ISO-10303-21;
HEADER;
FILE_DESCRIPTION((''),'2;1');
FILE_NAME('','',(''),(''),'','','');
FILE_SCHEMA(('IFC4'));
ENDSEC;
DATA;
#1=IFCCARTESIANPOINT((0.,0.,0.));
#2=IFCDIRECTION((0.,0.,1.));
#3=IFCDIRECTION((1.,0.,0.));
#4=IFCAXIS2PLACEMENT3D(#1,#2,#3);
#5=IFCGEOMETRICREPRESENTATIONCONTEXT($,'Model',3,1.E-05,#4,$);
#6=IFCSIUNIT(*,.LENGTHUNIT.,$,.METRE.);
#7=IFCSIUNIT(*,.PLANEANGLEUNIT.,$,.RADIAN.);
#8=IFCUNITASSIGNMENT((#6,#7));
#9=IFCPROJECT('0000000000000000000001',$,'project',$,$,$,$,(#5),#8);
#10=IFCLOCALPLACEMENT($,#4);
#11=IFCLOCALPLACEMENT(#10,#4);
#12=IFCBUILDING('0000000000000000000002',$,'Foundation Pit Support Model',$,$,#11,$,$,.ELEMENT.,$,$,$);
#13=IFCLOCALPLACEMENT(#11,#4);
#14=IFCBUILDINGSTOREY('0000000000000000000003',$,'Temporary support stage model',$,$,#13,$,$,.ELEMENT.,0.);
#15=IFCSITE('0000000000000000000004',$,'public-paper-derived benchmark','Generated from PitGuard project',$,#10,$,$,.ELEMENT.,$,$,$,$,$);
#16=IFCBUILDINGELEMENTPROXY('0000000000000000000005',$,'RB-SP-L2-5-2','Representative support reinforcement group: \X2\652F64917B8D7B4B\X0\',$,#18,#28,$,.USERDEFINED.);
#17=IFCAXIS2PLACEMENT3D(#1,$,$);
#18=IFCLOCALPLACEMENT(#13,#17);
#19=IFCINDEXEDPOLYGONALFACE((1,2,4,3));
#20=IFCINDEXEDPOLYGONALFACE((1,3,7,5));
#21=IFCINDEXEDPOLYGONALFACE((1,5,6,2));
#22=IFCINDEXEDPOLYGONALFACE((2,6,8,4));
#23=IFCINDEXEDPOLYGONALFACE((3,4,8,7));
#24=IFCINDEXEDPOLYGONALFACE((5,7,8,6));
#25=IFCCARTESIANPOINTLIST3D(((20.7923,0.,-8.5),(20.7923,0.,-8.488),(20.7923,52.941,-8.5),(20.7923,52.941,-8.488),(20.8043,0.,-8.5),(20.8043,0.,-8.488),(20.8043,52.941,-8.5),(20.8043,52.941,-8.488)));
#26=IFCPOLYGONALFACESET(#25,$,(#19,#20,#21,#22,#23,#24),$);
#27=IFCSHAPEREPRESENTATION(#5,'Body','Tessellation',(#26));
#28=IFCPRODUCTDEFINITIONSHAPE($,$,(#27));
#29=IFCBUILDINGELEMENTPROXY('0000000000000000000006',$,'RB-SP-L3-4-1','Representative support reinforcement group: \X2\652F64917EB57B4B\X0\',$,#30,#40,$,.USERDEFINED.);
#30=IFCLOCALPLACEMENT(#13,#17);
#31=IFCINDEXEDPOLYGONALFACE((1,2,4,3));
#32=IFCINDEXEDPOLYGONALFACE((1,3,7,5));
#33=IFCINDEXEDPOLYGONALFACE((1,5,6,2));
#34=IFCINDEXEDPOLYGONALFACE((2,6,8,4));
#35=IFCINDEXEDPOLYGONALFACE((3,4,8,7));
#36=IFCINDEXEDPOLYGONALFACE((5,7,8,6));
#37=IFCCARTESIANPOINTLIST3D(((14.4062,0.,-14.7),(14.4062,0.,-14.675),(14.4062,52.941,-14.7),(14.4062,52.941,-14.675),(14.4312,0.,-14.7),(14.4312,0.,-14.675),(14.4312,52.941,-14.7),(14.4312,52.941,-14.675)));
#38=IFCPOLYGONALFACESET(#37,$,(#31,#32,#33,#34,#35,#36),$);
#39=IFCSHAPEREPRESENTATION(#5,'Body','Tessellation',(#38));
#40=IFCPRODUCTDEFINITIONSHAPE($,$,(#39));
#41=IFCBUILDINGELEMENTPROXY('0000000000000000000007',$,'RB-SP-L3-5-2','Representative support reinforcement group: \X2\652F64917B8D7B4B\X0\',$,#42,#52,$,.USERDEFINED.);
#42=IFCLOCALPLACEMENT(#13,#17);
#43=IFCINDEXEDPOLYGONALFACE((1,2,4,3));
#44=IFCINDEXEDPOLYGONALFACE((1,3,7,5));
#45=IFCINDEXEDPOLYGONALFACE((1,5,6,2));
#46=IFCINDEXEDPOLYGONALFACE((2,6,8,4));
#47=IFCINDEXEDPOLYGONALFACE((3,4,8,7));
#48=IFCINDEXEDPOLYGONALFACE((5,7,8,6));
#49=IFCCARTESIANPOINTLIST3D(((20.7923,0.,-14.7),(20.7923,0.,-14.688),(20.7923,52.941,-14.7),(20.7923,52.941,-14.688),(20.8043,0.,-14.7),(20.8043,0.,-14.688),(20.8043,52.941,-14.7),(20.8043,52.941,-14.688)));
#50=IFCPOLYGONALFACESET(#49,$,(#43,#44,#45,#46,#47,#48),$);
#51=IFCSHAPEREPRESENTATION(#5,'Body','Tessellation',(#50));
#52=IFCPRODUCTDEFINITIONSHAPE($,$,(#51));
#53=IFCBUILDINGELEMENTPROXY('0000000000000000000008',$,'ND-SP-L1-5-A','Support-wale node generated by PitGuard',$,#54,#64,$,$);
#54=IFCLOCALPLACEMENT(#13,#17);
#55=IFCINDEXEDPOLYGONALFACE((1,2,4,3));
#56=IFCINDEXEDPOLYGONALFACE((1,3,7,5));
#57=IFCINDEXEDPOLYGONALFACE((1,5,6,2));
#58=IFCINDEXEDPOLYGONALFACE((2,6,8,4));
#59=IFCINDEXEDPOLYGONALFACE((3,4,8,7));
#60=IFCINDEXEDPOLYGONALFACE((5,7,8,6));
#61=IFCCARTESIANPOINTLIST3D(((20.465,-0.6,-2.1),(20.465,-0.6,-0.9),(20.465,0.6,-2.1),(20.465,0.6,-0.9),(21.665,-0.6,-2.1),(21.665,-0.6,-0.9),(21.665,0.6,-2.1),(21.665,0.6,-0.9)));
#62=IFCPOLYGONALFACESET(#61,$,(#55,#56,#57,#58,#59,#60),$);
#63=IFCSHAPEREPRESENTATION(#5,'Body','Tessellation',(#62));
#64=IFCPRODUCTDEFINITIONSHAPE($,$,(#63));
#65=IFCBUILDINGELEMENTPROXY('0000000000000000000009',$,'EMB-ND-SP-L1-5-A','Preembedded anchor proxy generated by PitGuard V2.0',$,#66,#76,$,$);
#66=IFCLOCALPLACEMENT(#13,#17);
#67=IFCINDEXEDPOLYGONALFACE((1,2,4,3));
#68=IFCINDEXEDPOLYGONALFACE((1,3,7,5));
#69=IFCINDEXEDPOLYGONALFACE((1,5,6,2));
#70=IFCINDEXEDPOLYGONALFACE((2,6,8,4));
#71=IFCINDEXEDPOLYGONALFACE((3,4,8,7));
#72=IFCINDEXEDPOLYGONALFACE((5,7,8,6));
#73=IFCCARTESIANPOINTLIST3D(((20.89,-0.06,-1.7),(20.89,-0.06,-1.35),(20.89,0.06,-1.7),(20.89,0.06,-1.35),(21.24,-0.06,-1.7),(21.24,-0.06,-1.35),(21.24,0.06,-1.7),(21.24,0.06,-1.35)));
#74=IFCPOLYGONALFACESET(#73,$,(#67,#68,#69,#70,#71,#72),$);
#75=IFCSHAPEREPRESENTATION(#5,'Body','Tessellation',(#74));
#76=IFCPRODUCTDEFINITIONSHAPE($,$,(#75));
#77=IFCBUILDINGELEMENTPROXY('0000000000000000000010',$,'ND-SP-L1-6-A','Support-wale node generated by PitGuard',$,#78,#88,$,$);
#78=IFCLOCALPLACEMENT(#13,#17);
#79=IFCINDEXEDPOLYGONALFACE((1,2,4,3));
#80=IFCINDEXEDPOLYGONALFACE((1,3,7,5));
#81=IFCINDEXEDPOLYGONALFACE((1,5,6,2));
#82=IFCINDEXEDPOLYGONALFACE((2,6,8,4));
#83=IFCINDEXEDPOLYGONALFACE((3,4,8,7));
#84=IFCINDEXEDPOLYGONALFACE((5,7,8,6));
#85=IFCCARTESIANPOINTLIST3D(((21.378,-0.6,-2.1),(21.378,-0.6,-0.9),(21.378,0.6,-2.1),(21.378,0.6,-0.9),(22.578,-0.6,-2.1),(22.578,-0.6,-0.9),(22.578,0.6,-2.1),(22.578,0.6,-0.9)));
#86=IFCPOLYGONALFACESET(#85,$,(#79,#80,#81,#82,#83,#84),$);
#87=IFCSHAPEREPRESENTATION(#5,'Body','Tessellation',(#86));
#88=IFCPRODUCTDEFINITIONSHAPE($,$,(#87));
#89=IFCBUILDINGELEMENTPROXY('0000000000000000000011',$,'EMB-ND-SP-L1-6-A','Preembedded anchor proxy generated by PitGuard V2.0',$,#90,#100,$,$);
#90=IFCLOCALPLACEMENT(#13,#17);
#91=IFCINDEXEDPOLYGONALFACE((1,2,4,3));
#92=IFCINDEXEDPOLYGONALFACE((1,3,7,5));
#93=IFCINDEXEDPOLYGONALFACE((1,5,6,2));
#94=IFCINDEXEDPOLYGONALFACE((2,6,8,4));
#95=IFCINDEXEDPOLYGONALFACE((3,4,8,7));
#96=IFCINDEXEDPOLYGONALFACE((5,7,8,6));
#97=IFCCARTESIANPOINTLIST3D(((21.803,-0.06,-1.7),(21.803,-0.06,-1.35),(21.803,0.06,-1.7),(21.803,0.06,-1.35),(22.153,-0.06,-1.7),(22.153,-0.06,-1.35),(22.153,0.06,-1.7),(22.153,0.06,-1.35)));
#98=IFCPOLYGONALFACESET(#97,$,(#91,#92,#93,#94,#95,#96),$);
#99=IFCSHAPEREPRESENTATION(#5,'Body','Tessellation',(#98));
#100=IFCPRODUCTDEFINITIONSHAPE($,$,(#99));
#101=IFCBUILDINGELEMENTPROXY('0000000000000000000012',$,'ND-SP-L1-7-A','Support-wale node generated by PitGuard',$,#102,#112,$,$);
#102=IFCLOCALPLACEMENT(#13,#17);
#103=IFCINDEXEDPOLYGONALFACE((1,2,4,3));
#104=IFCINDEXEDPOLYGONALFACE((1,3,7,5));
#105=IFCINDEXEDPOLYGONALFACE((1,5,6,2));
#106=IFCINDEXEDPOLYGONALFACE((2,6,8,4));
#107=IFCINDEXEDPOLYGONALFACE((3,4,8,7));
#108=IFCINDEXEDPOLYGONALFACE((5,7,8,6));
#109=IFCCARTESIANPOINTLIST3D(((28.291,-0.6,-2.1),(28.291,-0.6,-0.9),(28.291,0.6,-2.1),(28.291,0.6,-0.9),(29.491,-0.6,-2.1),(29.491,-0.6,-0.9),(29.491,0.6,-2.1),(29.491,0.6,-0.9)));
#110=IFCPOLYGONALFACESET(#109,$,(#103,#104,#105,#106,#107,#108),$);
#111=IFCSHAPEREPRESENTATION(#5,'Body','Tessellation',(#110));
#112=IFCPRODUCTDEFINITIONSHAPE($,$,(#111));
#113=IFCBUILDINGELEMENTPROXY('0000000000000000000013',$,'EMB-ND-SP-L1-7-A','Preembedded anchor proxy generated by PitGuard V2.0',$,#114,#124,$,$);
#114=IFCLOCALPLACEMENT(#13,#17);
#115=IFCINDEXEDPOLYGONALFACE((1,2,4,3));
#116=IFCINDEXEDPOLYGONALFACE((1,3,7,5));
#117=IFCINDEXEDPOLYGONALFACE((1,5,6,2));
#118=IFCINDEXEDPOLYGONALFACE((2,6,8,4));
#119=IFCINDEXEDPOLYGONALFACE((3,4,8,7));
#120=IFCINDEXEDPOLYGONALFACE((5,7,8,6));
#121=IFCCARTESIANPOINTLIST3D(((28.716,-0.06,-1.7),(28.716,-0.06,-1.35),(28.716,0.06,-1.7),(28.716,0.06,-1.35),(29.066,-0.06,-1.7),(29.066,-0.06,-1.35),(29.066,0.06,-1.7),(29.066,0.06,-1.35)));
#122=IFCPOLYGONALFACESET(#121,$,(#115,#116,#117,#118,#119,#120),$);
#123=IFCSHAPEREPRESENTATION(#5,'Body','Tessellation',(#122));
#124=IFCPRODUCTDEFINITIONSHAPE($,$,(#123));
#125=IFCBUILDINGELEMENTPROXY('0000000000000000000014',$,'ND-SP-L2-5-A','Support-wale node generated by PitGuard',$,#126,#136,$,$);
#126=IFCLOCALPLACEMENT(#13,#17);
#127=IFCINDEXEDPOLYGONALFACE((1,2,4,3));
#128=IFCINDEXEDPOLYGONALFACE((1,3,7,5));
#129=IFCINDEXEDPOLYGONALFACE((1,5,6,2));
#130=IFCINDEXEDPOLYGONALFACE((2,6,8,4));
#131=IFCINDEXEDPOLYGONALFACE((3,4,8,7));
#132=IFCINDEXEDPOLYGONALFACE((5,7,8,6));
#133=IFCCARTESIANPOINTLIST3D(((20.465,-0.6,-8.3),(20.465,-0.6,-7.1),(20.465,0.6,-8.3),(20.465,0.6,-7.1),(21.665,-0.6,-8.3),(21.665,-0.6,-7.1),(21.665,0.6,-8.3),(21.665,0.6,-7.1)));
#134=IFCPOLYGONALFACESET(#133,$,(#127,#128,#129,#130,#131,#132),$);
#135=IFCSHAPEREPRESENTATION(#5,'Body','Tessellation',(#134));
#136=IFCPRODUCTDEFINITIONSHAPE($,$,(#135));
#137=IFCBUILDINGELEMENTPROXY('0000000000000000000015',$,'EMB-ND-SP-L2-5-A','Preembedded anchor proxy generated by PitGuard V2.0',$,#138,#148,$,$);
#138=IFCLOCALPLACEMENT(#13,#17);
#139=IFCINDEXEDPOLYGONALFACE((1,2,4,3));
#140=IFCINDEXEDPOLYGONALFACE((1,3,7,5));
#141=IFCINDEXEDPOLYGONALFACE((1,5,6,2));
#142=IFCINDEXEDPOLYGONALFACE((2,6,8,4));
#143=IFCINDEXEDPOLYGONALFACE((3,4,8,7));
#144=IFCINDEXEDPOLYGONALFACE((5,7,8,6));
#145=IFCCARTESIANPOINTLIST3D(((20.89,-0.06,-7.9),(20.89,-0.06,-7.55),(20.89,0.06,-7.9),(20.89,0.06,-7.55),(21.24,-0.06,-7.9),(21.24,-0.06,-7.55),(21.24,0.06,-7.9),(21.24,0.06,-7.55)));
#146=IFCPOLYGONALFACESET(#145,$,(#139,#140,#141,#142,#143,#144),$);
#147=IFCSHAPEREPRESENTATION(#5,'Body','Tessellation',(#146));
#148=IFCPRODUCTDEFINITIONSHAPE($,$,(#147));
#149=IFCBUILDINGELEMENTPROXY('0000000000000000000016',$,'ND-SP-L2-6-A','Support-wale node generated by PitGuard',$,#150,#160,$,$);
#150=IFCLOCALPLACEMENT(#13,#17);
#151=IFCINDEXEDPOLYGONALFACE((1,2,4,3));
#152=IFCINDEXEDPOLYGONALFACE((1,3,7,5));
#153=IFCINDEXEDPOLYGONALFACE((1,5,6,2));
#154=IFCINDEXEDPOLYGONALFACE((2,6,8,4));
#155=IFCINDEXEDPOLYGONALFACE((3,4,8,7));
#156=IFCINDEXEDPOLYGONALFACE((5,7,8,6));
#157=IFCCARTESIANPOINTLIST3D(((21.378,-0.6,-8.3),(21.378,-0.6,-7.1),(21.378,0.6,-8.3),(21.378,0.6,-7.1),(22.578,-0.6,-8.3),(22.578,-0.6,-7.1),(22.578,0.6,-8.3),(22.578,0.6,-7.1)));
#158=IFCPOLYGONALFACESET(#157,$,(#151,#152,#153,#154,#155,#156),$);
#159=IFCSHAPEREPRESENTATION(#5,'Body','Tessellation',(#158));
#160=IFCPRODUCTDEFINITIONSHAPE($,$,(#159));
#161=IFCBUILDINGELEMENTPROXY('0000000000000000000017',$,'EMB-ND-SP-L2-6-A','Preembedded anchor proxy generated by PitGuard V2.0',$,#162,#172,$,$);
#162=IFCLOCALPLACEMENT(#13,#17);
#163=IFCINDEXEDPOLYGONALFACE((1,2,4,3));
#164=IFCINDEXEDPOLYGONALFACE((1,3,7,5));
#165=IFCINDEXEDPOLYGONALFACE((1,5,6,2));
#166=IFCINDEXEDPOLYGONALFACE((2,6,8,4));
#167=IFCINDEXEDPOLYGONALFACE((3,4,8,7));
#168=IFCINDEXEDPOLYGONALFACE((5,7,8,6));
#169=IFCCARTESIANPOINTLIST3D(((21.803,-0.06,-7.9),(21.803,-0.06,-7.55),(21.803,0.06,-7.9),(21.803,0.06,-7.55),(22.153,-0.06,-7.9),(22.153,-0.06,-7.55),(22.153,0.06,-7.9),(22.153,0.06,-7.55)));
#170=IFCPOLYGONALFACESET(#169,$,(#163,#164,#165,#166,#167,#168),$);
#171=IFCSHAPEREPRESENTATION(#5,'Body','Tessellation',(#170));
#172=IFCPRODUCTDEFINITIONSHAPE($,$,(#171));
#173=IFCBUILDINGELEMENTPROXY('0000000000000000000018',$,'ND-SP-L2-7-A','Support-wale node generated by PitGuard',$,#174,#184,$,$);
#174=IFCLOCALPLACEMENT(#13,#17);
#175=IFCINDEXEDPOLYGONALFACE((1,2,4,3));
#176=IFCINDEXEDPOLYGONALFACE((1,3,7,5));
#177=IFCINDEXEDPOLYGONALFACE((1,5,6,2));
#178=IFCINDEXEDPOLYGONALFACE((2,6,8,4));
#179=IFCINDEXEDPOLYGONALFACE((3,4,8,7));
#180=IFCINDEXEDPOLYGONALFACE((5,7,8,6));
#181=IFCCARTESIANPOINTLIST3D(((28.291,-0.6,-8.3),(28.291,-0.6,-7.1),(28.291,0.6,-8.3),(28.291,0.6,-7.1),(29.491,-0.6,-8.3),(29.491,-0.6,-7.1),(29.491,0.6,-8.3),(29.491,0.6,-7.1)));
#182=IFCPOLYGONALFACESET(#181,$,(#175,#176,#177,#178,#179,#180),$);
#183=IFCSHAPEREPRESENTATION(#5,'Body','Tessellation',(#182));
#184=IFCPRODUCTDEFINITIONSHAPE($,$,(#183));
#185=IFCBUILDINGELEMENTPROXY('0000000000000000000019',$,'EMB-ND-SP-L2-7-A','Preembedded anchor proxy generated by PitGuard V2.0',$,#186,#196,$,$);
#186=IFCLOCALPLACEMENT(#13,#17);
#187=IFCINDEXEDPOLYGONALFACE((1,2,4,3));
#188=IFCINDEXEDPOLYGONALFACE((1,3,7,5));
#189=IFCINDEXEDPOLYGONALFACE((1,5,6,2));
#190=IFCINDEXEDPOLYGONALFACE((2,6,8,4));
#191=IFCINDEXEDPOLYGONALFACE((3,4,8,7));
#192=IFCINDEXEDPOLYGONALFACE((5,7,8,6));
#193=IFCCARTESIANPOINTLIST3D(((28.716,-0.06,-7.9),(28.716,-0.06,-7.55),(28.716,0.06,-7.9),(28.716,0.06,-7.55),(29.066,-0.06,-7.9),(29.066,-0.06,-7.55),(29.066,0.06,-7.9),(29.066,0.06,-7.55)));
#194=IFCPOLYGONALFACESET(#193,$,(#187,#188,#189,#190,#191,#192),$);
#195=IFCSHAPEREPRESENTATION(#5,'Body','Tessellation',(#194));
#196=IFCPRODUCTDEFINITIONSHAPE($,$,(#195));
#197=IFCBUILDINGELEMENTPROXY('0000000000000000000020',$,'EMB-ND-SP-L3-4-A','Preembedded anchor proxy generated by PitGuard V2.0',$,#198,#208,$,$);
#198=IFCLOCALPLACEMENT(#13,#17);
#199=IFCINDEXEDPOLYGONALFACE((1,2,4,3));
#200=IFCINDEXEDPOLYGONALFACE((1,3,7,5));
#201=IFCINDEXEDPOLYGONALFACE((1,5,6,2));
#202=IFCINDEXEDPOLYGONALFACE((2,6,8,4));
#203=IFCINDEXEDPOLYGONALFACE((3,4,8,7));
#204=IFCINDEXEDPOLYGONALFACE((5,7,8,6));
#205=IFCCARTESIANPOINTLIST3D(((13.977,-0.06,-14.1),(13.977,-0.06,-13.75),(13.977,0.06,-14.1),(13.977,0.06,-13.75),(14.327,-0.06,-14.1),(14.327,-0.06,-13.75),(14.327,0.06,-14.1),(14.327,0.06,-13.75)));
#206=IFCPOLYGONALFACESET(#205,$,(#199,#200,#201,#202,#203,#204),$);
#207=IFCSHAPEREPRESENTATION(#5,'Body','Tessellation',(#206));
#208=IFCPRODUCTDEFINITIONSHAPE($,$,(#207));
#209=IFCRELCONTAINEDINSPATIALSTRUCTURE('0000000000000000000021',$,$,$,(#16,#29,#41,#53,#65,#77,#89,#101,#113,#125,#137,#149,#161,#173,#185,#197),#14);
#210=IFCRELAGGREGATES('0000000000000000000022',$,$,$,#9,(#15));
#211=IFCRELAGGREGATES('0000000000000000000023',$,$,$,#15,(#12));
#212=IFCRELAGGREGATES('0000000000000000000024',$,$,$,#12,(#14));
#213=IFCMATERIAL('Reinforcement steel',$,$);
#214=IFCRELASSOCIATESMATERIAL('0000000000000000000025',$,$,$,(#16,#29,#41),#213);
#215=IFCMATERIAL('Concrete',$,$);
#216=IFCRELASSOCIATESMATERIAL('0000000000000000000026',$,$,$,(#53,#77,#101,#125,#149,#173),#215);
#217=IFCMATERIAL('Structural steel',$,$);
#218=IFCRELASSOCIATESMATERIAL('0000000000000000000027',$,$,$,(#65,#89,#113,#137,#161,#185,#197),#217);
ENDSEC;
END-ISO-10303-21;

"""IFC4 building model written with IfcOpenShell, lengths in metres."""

from ifc_helpers import new_model, si_unit, frame, origin_with_axes, origin_2d, place, context, project, spatial, rectangle, extrude, material, element, save


model = new_model("IFC4")

# Units and contexts
model_context = context("Model", 3, precision=1e-05, world=origin_with_axes())
ifc_project = project(units=[si_unit("LENGTHUNIT", "METRE"), si_unit("PLANEANGLEUNIT", "RADIAN")], contexts=[model_context])

# Site, building, storey
site_placement = place(None, origin_with_axes())
site = spatial("IfcSite", under=ifc_project, at=site_placement, Name="public-paper-derived benchmark", Description="Generated from PitGuard project", CompositionType="ELEMENT")
building_placement = place(site_placement, origin_with_axes())
building = spatial("IfcBuilding", under=site, at=building_placement, Name="Foundation Pit Support Model", CompositionType="ELEMENT")
storey_placement = place(building_placement, origin_with_axes())
storey = spatial("IfcBuildingStorey", under=building, at=storey_placement, Name="Temporary support stage model", CompositionType="ELEMENT", Elevation=0.0)

# Shared definitions
ifc_material_1 = material(Name="Structural steel")

# Shared definitions
ifc_material_2 = material(Name="Concrete")

# Building element proxies
ifc_material_3 = material(Name="Reinforcement steel")
proxy_1_placement = place(storey_placement, frame((20.7983, 26.4705, -8.5), z_axis=(0.0, 0.0, 1.0), x_axis=(0.0, 1.0, 0.0)))
element("IfcBuildingElementProxy", 1, at=proxy_1_placement, inside=storey, material=ifc_material_3, Name="RB-SP-L2-5-2", Description="Representative support reinforcement group: 支撑箍筋", PredefinedType="USERDEFINED", context=model_context, shape_type="SweptSolid", body=[
    extrude(rectangle(XDim=52.941, YDim=0.012, at=origin_2d()), origin_with_axes(), (0.0, 0.0, 1.0), 0.012),
])
proxy_2_placement = place(storey_placement, frame((14.4187, 26.4705, -14.7), z_axis=(0.0, 0.0, 1.0), x_axis=(0.0, 1.0, 0.0)))
element("IfcBuildingElementProxy", 2, at=proxy_2_placement, inside=storey, material=ifc_material_3, Name="RB-SP-L3-4-1", Description="Representative support reinforcement group: 支撑纵筋", PredefinedType="USERDEFINED", context=model_context, shape_type="SweptSolid", body=[
    extrude(rectangle(XDim=52.941, YDim=0.025, at=origin_2d()), origin_with_axes(), (0.0, 0.0, 1.0), 0.025),
])
proxy_3_placement = place(storey_placement, frame((20.7983, 26.4705, -14.7), z_axis=(0.0, 0.0, 1.0), x_axis=(0.0, 1.0, 0.0)))
element("IfcBuildingElementProxy", 3, at=proxy_3_placement, inside=storey, material=ifc_material_3, Name="RB-SP-L3-5-2", Description="Representative support reinforcement group: 支撑箍筋", PredefinedType="USERDEFINED", context=model_context, shape_type="SweptSolid", body=[
    extrude(rectangle(XDim=52.941, YDim=0.012, at=origin_2d()), origin_with_axes(), (0.0, 0.0, 1.0), 0.012),
])
proxy_4_placement = place(storey_placement, frame((21.065, 0.0, -2.1), z_axis=(0.0, 0.0, 1.0), x_axis=(1.0, 0.0, 0.0)))
element("IfcBuildingElementProxy", 4, at=proxy_4_placement, inside=storey, material=ifc_material_2, Name="ND-SP-L1-5-A", Description="Support-wale node generated by PitGuard", context=model_context, shape_type="SweptSolid", body=[
    extrude(rectangle(XDim=1.2, YDim=1.2, at=origin_2d()), origin_with_axes(), (0.0, 0.0, 1.0), 1.2),
])
proxy_5_placement = place(storey_placement, frame((21.065, 0.0, -1.7), z_axis=(0.0, 0.0, 1.0), x_axis=(1.0, 0.0, 0.0)))
element("IfcBuildingElementProxy", 5, at=proxy_5_placement, inside=storey, material=ifc_material_1, Name="EMB-ND-SP-L1-5-A", Description="Preembedded anchor proxy generated by PitGuard V2.0", context=model_context, shape_type="SweptSolid", body=[
    extrude(rectangle(XDim=0.35, YDim=0.12, at=origin_2d()), origin_with_axes(), (0.0, 0.0, 1.0), 0.35),
])
proxy_6_placement = place(storey_placement, frame((21.978, 0.0, -2.1), z_axis=(0.0, 0.0, 1.0), x_axis=(1.0, 0.0, 0.0)))
element("IfcBuildingElementProxy", 6, at=proxy_6_placement, inside=storey, material=ifc_material_2, Name="ND-SP-L1-6-A", Description="Support-wale node generated by PitGuard", context=model_context, shape_type="SweptSolid", body=[
    extrude(rectangle(XDim=1.2, YDim=1.2, at=origin_2d()), origin_with_axes(), (0.0, 0.0, 1.0), 1.2),
])
proxy_7_placement = place(storey_placement, frame((21.978, 0.0, -1.7), z_axis=(0.0, 0.0, 1.0), x_axis=(1.0, 0.0, 0.0)))
element("IfcBuildingElementProxy", 7, at=proxy_7_placement, inside=storey, material=ifc_material_1, Name="EMB-ND-SP-L1-6-A", Description="Preembedded anchor proxy generated by PitGuard V2.0", context=model_context, shape_type="SweptSolid", body=[
    extrude(rectangle(XDim=0.35, YDim=0.12, at=origin_2d()), origin_with_axes(), (0.0, 0.0, 1.0), 0.35),
])
proxy_8_placement = place(storey_placement, frame((28.891, 0.0, -2.1), z_axis=(0.0, 0.0, 1.0), x_axis=(1.0, 0.0, 0.0)))
element("IfcBuildingElementProxy", 8, at=proxy_8_placement, inside=storey, material=ifc_material_2, Name="ND-SP-L1-7-A", Description="Support-wale node generated by PitGuard", context=model_context, shape_type="SweptSolid", body=[
    extrude(rectangle(XDim=1.2, YDim=1.2, at=origin_2d()), origin_with_axes(), (0.0, 0.0, 1.0), 1.2),
])
proxy_9_placement = place(storey_placement, frame((28.891, 0.0, -1.7), z_axis=(0.0, 0.0, 1.0), x_axis=(1.0, 0.0, 0.0)))
element("IfcBuildingElementProxy", 9, at=proxy_9_placement, inside=storey, material=ifc_material_1, Name="EMB-ND-SP-L1-7-A", Description="Preembedded anchor proxy generated by PitGuard V2.0", context=model_context, shape_type="SweptSolid", body=[
    extrude(rectangle(XDim=0.35, YDim=0.12, at=origin_2d()), origin_with_axes(), (0.0, 0.0, 1.0), 0.35),
])
proxy_10_placement = place(storey_placement, frame((21.065, 0.0, -8.3), z_axis=(0.0, 0.0, 1.0), x_axis=(1.0, 0.0, 0.0)))
element("IfcBuildingElementProxy", 10, at=proxy_10_placement, inside=storey, material=ifc_material_2, Name="ND-SP-L2-5-A", Description="Support-wale node generated by PitGuard", context=model_context, shape_type="SweptSolid", body=[
    extrude(rectangle(XDim=1.2, YDim=1.2, at=origin_2d()), origin_with_axes(), (0.0, 0.0, 1.0), 1.2),
])
proxy_11_placement = place(storey_placement, frame((21.065, 0.0, -7.9), z_axis=(0.0, 0.0, 1.0), x_axis=(1.0, 0.0, 0.0)))
element("IfcBuildingElementProxy", 11, at=proxy_11_placement, inside=storey, material=ifc_material_1, Name="EMB-ND-SP-L2-5-A", Description="Preembedded anchor proxy generated by PitGuard V2.0", context=model_context, shape_type="SweptSolid", body=[
    extrude(rectangle(XDim=0.35, YDim=0.12, at=origin_2d()), origin_with_axes(), (0.0, 0.0, 1.0), 0.35),
])
proxy_12_placement = place(storey_placement, frame((21.978, 0.0, -8.3), z_axis=(0.0, 0.0, 1.0), x_axis=(1.0, 0.0, 0.0)))
element("IfcBuildingElementProxy", 12, at=proxy_12_placement, inside=storey, material=ifc_material_2, Name="ND-SP-L2-6-A", Description="Support-wale node generated by PitGuard", context=model_context, shape_type="SweptSolid", body=[
    extrude(rectangle(XDim=1.2, YDim=1.2, at=origin_2d()), origin_with_axes(), (0.0, 0.0, 1.0), 1.2),
])
proxy_13_placement = place(storey_placement, frame((21.978, 0.0, -7.9), z_axis=(0.0, 0.0, 1.0), x_axis=(1.0, 0.0, 0.0)))
element("IfcBuildingElementProxy", 13, at=proxy_13_placement, inside=storey, material=ifc_material_1, Name="EMB-ND-SP-L2-6-A", Description="Preembedded anchor proxy generated by PitGuard V2.0", context=model_context, shape_type="SweptSolid", body=[
    extrude(rectangle(XDim=0.35, YDim=0.12, at=origin_2d()), origin_with_axes(), (0.0, 0.0, 1.0), 0.35),
])
proxy_14_placement = place(storey_placement, frame((28.891, 0.0, -8.3), z_axis=(0.0, 0.0, 1.0), x_axis=(1.0, 0.0, 0.0)))
element("IfcBuildingElementProxy", 14, at=proxy_14_placement, inside=storey, material=ifc_material_2, Name="ND-SP-L2-7-A", Description="Support-wale node generated by PitGuard", context=model_context, shape_type="SweptSolid", body=[
    extrude(rectangle(XDim=1.2, YDim=1.2, at=origin_2d()), origin_with_axes(), (0.0, 0.0, 1.0), 1.2),
])
for number, where, z_axis, x_axis, name in (
    (15, (28.891, 0.0, -7.9), (0.0, 0.0, 1.0), (1.0, 0.0, 0.0), "EMB-ND-SP-L2-7-A"),
    (16, (14.152, 0.0, -14.1), (0.0, 0.0, 1.0), (1.0, 0.0, 0.0), "EMB-ND-SP-L3-4-A"),
):
    element("IfcBuildingElementProxy", number, at=place(storey_placement, frame(where, z_axis=z_axis, x_axis=x_axis)), inside=storey, material=ifc_material_1, Name=name, Description="Preembedded anchor proxy generated by PitGuard V2.0", context=model_context, shape_type="SweptSolid", body=[
        extrude(rectangle(XDim=0.35, YDim=0.12, at=origin_2d()), origin_with_axes(), (0.0, 0.0, 1.0), 0.35),
    ])

save(model, "model.ifc")
